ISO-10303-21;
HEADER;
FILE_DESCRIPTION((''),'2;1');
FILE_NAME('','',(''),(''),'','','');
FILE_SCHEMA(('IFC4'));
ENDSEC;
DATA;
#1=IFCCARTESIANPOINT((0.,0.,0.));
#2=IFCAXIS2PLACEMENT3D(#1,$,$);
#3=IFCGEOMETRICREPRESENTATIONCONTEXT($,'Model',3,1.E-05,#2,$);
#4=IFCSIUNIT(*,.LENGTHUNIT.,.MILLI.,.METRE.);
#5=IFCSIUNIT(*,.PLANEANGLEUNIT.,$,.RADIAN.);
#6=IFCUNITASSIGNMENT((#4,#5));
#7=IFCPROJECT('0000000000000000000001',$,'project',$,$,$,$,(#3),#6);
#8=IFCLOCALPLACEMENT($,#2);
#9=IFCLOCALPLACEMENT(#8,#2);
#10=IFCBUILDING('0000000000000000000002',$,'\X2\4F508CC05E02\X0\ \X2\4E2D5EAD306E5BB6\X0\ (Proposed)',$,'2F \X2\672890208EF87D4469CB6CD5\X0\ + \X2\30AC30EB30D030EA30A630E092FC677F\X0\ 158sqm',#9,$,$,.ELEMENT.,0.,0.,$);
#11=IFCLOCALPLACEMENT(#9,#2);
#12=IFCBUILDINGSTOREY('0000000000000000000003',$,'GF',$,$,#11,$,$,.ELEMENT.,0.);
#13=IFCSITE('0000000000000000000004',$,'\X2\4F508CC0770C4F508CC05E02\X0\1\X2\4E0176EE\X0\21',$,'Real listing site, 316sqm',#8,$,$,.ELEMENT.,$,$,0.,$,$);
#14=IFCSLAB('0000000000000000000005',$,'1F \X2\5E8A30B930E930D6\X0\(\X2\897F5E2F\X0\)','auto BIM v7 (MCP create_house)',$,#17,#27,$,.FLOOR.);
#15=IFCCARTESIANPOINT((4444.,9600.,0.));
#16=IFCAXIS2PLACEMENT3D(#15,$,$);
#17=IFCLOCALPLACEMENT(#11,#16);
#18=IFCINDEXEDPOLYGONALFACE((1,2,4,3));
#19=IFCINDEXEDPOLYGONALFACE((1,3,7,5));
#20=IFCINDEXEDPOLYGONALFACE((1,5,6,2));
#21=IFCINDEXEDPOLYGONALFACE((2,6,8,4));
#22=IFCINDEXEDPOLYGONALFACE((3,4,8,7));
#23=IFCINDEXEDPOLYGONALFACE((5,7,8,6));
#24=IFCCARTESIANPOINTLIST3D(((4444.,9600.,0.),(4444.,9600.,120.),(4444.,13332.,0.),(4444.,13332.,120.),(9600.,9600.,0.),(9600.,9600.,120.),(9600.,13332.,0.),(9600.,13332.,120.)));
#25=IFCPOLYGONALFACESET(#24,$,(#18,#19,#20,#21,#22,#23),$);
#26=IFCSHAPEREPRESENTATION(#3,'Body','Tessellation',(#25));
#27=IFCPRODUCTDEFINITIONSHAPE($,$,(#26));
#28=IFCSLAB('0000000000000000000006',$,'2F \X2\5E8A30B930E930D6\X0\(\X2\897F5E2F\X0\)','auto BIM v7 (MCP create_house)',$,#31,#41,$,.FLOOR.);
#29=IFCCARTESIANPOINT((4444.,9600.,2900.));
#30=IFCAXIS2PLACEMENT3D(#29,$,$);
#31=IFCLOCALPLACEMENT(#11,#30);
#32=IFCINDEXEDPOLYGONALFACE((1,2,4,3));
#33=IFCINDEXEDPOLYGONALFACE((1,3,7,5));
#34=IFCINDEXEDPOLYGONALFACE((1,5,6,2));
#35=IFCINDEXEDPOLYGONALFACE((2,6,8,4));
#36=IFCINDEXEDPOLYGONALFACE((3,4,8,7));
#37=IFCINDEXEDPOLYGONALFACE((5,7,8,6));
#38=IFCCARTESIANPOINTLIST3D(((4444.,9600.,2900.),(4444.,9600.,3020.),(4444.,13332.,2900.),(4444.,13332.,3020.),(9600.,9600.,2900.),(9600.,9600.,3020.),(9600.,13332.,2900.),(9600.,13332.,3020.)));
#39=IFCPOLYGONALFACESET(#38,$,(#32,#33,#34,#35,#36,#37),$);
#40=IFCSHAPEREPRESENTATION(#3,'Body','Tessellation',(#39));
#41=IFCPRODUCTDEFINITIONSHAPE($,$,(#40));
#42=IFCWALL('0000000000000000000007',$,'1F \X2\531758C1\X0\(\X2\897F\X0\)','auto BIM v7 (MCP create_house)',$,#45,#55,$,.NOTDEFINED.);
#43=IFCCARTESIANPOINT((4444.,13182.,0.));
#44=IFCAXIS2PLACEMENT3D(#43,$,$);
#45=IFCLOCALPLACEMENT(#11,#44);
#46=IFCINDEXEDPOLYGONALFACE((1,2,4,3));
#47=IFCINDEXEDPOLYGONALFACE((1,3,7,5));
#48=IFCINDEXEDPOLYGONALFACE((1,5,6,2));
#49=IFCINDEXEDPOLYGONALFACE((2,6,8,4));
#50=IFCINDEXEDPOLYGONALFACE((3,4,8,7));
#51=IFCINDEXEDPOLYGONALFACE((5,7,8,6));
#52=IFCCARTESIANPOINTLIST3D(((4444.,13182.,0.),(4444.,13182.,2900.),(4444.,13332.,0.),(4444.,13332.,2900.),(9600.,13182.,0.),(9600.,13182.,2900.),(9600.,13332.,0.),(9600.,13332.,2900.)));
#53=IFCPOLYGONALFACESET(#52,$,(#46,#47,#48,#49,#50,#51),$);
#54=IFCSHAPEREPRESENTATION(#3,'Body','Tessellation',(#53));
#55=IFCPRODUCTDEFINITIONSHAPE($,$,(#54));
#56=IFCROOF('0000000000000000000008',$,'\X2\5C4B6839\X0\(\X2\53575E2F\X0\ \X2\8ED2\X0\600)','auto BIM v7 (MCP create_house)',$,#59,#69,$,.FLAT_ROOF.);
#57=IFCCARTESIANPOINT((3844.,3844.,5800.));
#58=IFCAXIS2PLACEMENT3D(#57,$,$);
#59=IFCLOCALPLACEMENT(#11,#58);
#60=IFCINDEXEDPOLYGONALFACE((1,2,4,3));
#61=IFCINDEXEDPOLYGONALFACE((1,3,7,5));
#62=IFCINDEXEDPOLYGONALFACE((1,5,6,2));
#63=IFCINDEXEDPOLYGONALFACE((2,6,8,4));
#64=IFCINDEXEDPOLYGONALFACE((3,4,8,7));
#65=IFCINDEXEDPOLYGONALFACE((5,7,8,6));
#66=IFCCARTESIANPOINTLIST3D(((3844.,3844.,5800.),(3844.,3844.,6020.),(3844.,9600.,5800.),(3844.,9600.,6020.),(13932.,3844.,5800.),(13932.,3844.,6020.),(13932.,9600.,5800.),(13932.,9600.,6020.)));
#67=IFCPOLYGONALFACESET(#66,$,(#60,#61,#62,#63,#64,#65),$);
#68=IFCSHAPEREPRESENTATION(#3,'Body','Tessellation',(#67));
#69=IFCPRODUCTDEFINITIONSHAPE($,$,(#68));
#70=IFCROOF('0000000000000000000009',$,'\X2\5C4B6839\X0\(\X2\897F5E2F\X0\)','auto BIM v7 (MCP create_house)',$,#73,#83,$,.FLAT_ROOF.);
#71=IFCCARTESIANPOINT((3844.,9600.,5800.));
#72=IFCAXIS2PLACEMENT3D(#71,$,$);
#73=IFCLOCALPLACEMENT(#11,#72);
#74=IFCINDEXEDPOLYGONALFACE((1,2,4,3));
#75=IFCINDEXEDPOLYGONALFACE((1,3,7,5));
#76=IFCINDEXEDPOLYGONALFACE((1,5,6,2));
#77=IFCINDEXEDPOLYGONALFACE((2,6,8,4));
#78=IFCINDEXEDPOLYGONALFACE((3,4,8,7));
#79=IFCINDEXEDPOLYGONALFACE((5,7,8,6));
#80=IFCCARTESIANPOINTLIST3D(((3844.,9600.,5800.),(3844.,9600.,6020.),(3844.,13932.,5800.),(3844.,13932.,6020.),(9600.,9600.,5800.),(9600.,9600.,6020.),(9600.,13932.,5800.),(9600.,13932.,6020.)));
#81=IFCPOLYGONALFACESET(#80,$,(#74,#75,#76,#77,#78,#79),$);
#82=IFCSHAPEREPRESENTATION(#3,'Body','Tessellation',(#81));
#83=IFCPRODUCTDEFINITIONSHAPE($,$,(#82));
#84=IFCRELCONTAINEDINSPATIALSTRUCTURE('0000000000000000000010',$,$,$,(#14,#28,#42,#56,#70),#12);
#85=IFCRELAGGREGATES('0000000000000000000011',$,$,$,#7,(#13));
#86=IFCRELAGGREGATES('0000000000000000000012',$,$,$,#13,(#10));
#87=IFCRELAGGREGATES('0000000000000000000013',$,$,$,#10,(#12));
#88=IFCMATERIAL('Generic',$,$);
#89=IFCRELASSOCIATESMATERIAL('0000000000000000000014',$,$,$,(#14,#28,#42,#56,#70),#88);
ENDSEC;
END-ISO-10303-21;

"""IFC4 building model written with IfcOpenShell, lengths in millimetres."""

from ifc_helpers import new_model, si_unit, frame, frame_2d, origin, place, context, project, spatial, rectangle, extrude, material, element, save


model = new_model("IFC4")

# Units and contexts
model_context = context("Model", 3, precision=1e-05, world=origin())
ifc_project = project(units=[si_unit("LENGTHUNIT", "METRE", prefix="MILLI"), si_unit("PLANEANGLEUNIT", "RADIAN")], contexts=[model_context])

# Site, building, storey
site_placement = place(None, origin())
site = spatial("IfcSite", under=ifc_project, at=site_placement, Name="佐賀県佐賀市1丁目21", ObjectType="Real listing site, 316sqm", CompositionType="ELEMENT", RefElevation=0.0)
building_placement = place(site_placement, origin())
building = spatial("IfcBuilding", under=site, at=building_placement, Name="佐賀市 中庭の家 (Proposed)", ObjectType="2F 木造軸組構法 + ガルバリウム鋼板 158sqm", CompositionType="ELEMENT", ElevationOfRefHeight=0.0, ElevationOfTerrain=0.0)
storey_placement = place(building_placement, origin())
storey = spatial("IfcBuildingStorey", under=building, at=storey_placement, Name="GF", CompositionType="ELEMENT", Elevation=0.0)

# Slabs
ifc_material = material(Name="Generic")
slab_1_placement = place(storey_placement, frame((4444.0, 9600.0, 0.0)))
element("IfcSlab", 1, at=slab_1_placement, inside=storey, material=ifc_material, Name="1F 床スラブ(西帯)", Description="auto BIM v7 (MCP create_house)", PredefinedType="FLOOR", context=model_context, shape_type="SweptSolid", body=[
    extrude(rectangle(XDim=5156.0, YDim=3732.0, at=frame_2d((2578.0, 1866.0))), frame((4444.0, 9600.0, 0.0)), (0.0, 0.0, 1.0), 120.0),
])
slab_2_placement = place(storey_placement, frame((4444.0, 9600.0, 2900.0)))
element("IfcSlab", 2, at=slab_2_placement, inside=storey, material=ifc_material, Name="2F 床スラブ(西帯)", Description="auto BIM v7 (MCP create_house)", PredefinedType="FLOOR", context=model_context, shape_type="SweptSolid", body=[
    extrude(rectangle(XDim=5156.0, YDim=3732.0, at=frame_2d((2578.0, 1866.0))), frame((4444.0, 9600.0, 2900.0)), (0.0, 0.0, 1.0), 120.0),
])

# Wall
wall_1_placement = place(storey_placement, frame((4444.0, 13182.0, 0.0)))
element("IfcWall", 3, at=wall_1_placement, inside=storey, material=ifc_material, Name="1F 北壁(西)", Description="auto BIM v7 (MCP create_house)", PredefinedType="NOTDEFINED", context=model_context, shape_type="SweptSolid", body=[
    extrude(rectangle(XDim=5156.0, YDim=150.0, at=frame_2d((2578.0, 75.0))), frame((4444.0, 13182.0, 0.0)), (0.0, 0.0, 1.0), 2900.0),
])

# Roofs
roof_1_placement = place(storey_placement, frame((3844.0, 3844.0, 5800.0)))
element("IfcRoof", 4, at=roof_1_placement, inside=storey, material=ifc_material, Name="屋根(南帯 軒600)", Description="auto BIM v7 (MCP create_house)", PredefinedType="FLAT_ROOF", context=model_context, shape_type="SweptSolid", body=[
    extrude(rectangle(XDim=10088.0, YDim=5756.0, at=frame_2d((5044.0, 2878.0))), frame((3844.0, 3844.0, 5800.0)), (0.0, 0.0, 1.0), 220.0),
])
roof_2_placement = place(storey_placement, frame((3844.0, 9600.0, 5800.0)))
element("IfcRoof", 5, at=roof_2_placement, inside=storey, material=ifc_material, Name="屋根(西帯)", Description="auto BIM v7 (MCP create_house)", PredefinedType="FLAT_ROOF", context=model_context, shape_type="SweptSolid", body=[
    extrude(rectangle(XDim=5756.0, YDim=4332.0, at=frame_2d((2878.0, 2166.0))), frame((3844.0, 9600.0, 5800.0)), (0.0, 0.0, 1.0), 220.0),
])

save(model, "model.ifc")
